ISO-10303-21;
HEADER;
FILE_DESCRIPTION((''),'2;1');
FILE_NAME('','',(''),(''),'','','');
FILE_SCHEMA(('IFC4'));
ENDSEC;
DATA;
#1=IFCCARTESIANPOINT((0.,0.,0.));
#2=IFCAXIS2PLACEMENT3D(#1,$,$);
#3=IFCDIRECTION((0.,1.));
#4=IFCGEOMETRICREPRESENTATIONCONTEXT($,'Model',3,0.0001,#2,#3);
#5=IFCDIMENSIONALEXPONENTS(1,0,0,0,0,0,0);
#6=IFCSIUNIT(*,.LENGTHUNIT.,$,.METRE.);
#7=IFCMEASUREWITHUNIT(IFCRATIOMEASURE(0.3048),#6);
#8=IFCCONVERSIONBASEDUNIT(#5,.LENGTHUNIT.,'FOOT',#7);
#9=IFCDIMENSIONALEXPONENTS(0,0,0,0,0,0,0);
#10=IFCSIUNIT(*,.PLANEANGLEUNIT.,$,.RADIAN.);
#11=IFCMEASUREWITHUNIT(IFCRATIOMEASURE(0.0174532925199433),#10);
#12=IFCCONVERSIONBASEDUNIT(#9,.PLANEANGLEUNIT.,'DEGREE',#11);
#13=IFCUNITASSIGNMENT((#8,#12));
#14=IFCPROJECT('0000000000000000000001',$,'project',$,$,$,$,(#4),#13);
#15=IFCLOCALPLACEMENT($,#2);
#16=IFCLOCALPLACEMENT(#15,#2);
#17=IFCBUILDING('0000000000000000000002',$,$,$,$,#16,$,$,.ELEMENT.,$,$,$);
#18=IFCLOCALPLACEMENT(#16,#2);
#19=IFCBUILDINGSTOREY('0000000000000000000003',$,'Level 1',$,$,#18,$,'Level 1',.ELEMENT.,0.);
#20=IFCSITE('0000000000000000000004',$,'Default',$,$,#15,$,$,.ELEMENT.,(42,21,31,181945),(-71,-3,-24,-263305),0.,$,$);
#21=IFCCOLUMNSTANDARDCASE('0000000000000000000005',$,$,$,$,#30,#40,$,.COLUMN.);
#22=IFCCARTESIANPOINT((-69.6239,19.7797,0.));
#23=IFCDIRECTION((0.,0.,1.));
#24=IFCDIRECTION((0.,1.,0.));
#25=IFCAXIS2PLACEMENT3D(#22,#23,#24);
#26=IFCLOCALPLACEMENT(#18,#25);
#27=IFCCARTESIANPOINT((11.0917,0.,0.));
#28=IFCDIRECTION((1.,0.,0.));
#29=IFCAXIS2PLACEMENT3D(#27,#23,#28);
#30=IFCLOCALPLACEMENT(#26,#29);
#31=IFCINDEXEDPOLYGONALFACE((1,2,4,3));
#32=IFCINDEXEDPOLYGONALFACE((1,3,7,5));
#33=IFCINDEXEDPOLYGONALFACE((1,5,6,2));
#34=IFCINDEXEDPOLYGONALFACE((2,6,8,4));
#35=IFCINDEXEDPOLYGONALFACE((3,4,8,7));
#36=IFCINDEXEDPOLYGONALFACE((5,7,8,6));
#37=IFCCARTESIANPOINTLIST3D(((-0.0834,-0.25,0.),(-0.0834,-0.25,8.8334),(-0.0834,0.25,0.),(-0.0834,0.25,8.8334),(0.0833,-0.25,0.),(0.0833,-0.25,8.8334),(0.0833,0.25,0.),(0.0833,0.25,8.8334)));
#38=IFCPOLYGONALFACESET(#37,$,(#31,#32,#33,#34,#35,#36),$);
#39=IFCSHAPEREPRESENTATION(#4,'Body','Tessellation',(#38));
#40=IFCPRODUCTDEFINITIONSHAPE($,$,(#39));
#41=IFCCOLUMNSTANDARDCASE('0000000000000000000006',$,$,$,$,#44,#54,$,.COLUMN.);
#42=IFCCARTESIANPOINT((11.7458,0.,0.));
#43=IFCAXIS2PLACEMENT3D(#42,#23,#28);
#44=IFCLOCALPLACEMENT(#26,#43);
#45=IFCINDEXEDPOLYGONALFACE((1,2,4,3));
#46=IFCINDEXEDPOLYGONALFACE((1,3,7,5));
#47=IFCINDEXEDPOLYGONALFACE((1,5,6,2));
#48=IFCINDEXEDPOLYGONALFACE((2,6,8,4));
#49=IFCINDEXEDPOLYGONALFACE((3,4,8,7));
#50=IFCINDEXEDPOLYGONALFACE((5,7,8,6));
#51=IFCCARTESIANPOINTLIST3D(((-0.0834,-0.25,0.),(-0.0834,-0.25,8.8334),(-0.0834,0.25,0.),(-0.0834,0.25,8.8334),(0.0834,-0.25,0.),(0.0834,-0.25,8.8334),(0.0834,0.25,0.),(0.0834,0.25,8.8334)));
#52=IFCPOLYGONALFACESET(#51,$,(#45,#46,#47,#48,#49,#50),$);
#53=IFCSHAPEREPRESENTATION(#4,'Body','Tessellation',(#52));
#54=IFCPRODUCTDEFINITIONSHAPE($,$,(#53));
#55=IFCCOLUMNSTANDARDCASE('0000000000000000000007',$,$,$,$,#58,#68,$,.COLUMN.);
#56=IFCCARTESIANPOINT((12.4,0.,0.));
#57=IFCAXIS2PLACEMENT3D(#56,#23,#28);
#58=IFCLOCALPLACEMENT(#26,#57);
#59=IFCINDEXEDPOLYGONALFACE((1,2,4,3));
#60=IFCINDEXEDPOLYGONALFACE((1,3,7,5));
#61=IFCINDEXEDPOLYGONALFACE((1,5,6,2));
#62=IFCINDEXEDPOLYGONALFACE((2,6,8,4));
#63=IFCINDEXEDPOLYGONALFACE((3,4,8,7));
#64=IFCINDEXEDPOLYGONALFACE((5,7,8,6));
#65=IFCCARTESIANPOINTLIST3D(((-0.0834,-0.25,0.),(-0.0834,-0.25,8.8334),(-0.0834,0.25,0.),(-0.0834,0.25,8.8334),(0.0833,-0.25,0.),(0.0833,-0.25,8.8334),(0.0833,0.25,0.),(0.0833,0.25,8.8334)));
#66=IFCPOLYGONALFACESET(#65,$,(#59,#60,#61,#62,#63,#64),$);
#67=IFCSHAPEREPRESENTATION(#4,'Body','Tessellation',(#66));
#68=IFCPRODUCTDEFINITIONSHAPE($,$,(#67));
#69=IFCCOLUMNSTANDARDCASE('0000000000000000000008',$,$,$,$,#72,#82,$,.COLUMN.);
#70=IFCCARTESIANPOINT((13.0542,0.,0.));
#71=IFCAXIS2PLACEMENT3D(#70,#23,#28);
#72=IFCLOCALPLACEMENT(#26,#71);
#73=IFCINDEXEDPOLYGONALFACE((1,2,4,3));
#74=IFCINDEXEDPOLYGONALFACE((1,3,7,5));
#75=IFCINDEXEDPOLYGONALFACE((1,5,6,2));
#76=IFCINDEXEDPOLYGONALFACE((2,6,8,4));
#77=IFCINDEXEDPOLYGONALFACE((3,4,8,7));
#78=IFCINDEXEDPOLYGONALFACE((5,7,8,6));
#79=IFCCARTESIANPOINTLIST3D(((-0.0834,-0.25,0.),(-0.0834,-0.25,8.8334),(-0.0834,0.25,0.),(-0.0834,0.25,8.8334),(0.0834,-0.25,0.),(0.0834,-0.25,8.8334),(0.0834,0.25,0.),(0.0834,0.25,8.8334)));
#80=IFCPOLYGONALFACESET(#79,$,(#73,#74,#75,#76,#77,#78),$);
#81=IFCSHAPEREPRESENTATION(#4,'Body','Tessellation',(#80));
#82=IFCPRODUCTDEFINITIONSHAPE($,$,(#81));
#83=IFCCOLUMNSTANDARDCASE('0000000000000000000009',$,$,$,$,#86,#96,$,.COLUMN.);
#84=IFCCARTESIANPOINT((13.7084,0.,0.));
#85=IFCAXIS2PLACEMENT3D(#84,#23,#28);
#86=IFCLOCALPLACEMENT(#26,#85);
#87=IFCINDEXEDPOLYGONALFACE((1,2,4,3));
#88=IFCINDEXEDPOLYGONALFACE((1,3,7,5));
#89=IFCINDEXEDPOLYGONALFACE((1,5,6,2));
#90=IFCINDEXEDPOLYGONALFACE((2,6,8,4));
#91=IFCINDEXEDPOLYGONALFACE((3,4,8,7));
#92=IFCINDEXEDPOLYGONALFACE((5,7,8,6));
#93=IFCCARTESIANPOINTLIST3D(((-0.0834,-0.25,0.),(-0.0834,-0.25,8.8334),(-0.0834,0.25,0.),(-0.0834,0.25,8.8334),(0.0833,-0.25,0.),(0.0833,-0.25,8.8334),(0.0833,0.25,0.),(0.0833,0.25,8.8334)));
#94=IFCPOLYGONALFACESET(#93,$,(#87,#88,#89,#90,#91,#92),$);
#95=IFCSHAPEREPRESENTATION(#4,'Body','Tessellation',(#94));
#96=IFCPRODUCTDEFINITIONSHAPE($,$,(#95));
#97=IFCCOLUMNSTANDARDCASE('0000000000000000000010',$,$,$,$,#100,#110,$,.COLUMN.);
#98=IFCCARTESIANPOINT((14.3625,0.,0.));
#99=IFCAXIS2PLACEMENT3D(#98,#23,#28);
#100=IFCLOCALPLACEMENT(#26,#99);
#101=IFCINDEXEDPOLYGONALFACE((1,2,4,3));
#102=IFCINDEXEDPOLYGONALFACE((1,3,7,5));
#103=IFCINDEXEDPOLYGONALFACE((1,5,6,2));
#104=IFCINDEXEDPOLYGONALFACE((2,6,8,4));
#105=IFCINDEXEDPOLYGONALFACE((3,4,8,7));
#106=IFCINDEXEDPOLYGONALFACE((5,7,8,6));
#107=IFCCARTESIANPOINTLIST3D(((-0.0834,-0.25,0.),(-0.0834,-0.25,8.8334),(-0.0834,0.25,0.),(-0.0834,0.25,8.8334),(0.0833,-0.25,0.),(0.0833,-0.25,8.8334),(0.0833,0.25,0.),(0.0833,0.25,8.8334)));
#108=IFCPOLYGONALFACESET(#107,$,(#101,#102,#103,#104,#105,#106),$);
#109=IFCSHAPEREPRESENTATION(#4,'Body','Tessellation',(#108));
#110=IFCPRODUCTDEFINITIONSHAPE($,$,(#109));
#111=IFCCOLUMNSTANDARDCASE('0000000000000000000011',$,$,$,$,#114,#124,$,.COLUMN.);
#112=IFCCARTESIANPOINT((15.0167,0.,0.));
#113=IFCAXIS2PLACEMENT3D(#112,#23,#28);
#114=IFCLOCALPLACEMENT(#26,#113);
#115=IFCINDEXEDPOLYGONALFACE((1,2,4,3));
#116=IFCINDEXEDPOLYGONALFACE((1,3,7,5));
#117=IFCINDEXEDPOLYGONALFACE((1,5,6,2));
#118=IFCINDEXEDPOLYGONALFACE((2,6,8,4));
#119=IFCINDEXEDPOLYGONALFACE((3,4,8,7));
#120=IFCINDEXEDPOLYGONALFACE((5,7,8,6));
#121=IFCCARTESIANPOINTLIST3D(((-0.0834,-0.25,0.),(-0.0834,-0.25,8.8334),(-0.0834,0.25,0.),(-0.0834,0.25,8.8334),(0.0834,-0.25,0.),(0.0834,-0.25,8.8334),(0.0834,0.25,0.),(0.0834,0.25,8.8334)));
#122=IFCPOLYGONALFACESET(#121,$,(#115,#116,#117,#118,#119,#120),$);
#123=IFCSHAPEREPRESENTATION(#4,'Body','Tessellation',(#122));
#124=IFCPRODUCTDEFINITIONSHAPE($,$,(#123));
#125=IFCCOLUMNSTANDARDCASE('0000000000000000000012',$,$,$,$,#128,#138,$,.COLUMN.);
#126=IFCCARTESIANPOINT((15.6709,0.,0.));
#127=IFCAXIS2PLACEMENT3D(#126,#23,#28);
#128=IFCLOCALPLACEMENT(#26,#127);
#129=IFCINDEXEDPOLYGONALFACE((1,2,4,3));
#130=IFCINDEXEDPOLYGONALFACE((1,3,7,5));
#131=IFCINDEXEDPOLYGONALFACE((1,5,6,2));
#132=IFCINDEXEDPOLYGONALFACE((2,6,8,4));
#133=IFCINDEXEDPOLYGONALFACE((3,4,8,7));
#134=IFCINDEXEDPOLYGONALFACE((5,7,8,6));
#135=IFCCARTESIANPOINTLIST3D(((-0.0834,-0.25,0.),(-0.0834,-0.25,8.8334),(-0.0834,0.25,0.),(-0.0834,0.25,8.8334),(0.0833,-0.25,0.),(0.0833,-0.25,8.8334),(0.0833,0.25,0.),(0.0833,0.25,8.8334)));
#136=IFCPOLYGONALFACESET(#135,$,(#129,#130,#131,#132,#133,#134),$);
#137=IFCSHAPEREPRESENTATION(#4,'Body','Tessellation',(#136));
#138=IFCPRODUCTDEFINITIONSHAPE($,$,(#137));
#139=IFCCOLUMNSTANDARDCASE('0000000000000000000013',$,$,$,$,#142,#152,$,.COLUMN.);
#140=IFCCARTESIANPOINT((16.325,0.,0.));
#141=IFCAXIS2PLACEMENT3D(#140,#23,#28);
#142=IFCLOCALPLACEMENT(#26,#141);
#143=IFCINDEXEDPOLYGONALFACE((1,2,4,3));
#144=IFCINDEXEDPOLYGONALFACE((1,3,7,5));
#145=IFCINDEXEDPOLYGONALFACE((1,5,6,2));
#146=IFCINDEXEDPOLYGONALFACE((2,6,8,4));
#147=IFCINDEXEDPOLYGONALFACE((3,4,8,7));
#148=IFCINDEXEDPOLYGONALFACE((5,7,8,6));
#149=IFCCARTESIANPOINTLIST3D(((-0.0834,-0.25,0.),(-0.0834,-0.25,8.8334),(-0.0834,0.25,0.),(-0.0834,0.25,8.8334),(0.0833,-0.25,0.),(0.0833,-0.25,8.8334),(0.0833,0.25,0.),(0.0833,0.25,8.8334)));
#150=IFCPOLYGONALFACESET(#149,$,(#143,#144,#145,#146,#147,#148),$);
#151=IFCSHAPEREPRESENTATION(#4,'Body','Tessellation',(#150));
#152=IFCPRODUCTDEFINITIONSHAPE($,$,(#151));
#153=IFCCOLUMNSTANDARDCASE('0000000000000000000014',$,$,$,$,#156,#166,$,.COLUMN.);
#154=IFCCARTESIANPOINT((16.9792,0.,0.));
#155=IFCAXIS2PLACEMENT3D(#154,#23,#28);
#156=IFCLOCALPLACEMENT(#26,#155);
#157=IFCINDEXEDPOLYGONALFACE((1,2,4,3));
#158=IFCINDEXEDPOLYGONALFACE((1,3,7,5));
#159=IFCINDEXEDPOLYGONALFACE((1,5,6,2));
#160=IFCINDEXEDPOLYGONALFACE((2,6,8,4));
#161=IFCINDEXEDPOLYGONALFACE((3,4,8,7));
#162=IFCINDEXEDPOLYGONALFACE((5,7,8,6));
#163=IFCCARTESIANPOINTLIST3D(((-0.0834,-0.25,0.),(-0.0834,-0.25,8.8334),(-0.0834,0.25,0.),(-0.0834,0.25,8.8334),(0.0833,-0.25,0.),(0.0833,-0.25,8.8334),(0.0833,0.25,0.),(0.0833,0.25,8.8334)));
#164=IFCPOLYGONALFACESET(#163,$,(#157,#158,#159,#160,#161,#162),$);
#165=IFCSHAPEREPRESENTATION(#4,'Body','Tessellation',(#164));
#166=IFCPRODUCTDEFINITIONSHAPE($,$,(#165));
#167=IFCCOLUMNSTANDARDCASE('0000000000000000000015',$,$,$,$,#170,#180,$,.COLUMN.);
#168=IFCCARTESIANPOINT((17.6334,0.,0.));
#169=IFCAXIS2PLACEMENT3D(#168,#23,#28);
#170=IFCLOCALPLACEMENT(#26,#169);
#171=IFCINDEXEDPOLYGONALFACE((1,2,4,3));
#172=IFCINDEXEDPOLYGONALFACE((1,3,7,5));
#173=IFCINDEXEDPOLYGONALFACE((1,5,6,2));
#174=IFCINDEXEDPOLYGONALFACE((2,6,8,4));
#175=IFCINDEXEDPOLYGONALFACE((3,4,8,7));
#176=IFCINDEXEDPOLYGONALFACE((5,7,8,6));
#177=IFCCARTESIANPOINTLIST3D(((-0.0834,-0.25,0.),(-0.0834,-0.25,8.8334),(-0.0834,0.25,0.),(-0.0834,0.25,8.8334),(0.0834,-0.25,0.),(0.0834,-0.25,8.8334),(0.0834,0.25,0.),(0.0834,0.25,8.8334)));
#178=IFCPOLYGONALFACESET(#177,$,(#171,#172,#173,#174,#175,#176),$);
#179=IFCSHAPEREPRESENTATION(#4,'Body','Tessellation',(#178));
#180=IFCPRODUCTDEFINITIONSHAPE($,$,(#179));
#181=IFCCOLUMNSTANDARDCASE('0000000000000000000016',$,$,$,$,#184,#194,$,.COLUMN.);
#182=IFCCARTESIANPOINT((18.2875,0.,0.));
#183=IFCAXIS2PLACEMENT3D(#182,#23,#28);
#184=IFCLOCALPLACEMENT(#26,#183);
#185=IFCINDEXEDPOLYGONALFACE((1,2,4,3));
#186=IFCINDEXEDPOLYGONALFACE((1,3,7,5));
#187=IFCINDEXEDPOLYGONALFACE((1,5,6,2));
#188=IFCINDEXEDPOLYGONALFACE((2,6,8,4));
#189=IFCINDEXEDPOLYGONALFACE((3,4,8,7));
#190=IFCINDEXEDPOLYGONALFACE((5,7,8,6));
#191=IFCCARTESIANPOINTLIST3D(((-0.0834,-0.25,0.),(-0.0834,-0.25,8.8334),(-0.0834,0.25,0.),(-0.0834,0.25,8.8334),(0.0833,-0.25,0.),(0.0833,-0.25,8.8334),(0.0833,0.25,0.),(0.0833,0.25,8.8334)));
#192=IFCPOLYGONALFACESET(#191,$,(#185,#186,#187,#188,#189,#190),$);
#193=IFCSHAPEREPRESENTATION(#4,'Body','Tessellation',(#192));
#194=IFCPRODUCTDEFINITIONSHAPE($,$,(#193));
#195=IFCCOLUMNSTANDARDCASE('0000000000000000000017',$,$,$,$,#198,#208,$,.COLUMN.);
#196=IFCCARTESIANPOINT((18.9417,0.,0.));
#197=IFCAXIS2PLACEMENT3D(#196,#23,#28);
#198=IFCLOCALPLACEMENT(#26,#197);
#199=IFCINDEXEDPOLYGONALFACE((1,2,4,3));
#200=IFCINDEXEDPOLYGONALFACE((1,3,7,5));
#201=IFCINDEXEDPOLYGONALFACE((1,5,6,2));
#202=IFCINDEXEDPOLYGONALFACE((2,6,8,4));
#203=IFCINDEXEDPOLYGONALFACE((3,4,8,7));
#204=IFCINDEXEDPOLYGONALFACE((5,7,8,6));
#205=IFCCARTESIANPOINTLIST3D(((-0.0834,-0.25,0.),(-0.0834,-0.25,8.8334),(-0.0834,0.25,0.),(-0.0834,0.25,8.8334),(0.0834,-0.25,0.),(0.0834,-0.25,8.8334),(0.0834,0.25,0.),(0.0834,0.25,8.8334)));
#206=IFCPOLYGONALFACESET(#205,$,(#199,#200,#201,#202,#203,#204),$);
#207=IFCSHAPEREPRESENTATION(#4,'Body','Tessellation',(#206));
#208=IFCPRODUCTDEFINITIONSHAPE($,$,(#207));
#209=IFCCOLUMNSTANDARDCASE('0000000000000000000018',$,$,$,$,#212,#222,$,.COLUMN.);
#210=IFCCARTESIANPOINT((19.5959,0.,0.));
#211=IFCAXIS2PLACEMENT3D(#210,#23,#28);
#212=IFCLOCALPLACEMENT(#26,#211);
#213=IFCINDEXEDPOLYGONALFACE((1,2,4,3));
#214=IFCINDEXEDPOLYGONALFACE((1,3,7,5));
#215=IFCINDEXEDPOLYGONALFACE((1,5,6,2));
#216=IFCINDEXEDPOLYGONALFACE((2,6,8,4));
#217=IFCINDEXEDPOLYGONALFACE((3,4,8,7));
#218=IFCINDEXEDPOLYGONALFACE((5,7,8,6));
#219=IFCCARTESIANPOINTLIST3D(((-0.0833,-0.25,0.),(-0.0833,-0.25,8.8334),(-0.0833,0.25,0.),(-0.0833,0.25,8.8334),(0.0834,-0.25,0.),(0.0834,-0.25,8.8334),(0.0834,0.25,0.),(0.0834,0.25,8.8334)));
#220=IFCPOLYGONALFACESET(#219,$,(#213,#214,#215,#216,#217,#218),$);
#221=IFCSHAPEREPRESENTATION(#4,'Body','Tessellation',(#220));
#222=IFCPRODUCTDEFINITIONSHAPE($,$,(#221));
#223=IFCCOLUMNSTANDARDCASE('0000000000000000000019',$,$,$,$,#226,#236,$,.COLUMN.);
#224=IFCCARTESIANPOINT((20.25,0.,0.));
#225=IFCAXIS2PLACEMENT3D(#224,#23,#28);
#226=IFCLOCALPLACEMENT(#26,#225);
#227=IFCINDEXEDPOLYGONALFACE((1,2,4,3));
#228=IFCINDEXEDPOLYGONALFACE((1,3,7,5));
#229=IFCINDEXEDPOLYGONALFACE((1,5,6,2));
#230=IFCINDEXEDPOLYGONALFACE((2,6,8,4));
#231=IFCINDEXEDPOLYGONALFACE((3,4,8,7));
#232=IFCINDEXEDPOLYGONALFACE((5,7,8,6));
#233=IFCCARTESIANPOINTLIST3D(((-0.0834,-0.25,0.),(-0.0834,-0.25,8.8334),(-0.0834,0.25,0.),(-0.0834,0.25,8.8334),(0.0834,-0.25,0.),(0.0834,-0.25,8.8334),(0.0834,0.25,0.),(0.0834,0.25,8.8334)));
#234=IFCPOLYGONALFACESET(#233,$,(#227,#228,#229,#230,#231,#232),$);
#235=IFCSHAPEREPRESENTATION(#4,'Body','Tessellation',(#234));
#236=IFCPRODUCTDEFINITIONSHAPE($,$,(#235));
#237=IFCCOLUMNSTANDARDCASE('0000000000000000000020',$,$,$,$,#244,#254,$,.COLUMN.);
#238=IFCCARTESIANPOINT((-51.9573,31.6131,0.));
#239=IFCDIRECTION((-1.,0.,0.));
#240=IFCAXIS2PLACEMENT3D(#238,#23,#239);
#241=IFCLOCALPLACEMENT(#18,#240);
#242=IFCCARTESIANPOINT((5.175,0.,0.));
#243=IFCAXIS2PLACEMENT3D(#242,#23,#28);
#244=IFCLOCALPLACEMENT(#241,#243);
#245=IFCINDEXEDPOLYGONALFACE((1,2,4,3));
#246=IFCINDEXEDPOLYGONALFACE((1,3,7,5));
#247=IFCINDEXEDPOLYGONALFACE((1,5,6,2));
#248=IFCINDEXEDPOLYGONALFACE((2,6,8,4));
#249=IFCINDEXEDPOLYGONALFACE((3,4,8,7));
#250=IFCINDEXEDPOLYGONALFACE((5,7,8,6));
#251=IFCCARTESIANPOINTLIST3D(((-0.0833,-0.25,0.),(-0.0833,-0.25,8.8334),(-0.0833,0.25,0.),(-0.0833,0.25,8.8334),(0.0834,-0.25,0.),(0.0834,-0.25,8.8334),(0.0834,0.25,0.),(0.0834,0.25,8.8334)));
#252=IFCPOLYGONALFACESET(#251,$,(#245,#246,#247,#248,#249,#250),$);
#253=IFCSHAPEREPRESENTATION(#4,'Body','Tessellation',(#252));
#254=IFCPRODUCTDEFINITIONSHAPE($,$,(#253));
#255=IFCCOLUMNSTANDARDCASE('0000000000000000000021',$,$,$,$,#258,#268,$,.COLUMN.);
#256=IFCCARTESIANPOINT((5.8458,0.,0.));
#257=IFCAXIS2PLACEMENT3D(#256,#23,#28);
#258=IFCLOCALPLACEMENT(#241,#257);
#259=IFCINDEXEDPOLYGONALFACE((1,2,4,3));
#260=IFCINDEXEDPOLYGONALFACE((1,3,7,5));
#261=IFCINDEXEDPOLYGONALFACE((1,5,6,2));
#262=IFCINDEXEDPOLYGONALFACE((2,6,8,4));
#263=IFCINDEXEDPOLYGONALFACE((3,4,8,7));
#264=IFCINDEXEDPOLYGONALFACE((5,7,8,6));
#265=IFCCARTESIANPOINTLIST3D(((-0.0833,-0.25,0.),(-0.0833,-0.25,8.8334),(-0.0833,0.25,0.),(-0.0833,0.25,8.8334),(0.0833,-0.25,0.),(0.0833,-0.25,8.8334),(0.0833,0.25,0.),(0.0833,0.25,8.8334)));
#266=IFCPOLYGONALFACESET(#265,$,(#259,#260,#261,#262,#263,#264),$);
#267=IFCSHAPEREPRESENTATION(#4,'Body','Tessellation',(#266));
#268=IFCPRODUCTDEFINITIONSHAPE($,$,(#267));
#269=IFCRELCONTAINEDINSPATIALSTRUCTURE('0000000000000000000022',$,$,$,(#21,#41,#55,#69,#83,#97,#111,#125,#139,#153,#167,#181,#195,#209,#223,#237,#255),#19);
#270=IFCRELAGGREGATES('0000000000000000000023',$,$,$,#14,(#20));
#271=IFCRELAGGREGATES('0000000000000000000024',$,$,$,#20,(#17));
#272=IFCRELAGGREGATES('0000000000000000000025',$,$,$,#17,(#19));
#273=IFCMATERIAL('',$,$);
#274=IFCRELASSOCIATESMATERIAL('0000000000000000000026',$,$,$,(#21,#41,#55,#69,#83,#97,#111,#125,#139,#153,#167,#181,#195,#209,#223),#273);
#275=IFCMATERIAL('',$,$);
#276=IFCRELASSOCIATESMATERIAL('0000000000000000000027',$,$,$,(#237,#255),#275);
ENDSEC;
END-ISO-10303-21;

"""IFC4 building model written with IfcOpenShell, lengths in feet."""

from ifc_helpers import new_model, entity, si_unit, converted_unit, direction, frame, origin, place, context, project, spatial, rectangle, extrude, material, element, save


model = new_model("IFC4")

# Units and contexts
model_context = context("Model", 3, precision=0.0001, world=origin(), true_north=direction((0.0, 1.0)))
ifc_project = project(units=[converted_unit("LENGTHUNIT", "FOOT", entity("IfcRatioMeasure", 0.3048), si_unit("LENGTHUNIT", "METRE"), dimensions=[1, 0, 0, 0, 0, 0, 0]), converted_unit("PLANEANGLEUNIT", "DEGREE", entity("IfcRatioMeasure", 0.0174532925199433), si_unit("PLANEANGLEUNIT", "RADIAN"), dimensions=[0, 0, 0, 0, 0, 0, 0])], contexts=[model_context])

# Site, building, storey
site_placement = place(None, origin())
site = spatial("IfcSite", under=ifc_project, at=site_placement, Name="Default", CompositionType="ELEMENT", RefLatitude=(42, 21, 31, 181945), RefLongitude=(-71, -3, -24, -263305), RefElevation=0.0)
building_placement = place(site_placement, origin())
building = spatial("IfcBuilding", under=site, at=building_placement, CompositionType="ELEMENT")
storey_placement = place(building_placement, origin())
storey = spatial("IfcBuildingStorey", under=building, at=storey_placement, Name="Level 1", LongName="Level 1", CompositionType="ELEMENT", Elevation=0.0)

# Columns
ifc_material_1 = material(Name="")
placement_1 = place(storey_placement, frame((-69.6239, 19.7797, 0.0), z_axis=(0.0, 0.0, 1.0), x_axis=(0.0, 1.0, 0.0)))
for number, where, z_axis, x_axis in (
    (1, (11.0917, 0.0, 0.0), (0.0, 0.0, 1.0), (1.0, 0.0, 0.0)),
    (2, (11.7458, 0.0, 0.0), (0.0, 0.0, 1.0), (1.0, 0.0, 0.0)),
    (3, (12.4, 0.0, 0.0), (0.0, 0.0, 1.0), (1.0, 0.0, 0.0)),
    (4, (13.0542, 0.0, 0.0), (0.0, 0.0, 1.0), (1.0, 0.0, 0.0)),
    (5, (13.7084, 0.0, 0.0), (0.0, 0.0, 1.0), (1.0, 0.0, 0.0)),
    (6, (14.3625, 0.0, 0.0), (0.0, 0.0, 1.0), (1.0, 0.0, 0.0)),
    (7, (15.0167, 0.0, 0.0), (0.0, 0.0, 1.0), (1.0, 0.0, 0.0)),
    (8, (15.6709, 0.0, 0.0), (0.0, 0.0, 1.0), (1.0, 0.0, 0.0)),
    (9, (16.325, 0.0, 0.0), (0.0, 0.0, 1.0), (1.0, 0.0, 0.0)),
    (10, (16.9792, 0.0, 0.0), (0.0, 0.0, 1.0), (1.0, 0.0, 0.0)),
    (11, (17.6334, 0.0, 0.0), (0.0, 0.0, 1.0), (1.0, 0.0, 0.0)),
    (12, (18.2875, 0.0, 0.0), (0.0, 0.0, 1.0), (1.0, 0.0, 0.0)),
    (13, (18.9417, 0.0, 0.0), (0.0, 0.0, 1.0), (1.0, 0.0, 0.0)),
    (14, (19.5959, 0.0, 0.0), (0.0, 0.0, 1.0), (1.0, 0.0, 0.0)),
    (15, (20.25, 0.0, 0.0), (0.0, 0.0, 1.0), (1.0, 0.0, 0.0)),
):
    element("IfcColumnStandardCase", number, at=place(placement_1, frame(where, z_axis=z_axis, x_axis=x_axis)), inside=storey, material=ifc_material_1, PredefinedType="COLUMN", context=model_context, shape_type="SweptSolid", body=[
        extrude(rectangle(XDim=0.1667, YDim=0.5), origin(), (0.0, 0.0, 1.0), 8.8334),
    ])
ifc_material_2 = material(Name="")
placement_2 = place(storey_placement, frame((-51.9573, 31.6131, 0.0), z_axis=(0.0, 0.0, 1.0), x_axis=(-1.0, 0.0, 0.0)))
for number, where, z_axis, x_axis in (
    (16, (5.175, 0.0, 0.0), (0.0, 0.0, 1.0), (1.0, 0.0, 0.0)),
    (17, (5.8458, 0.0, 0.0), (0.0, 0.0, 1.0), (1.0, 0.0, 0.0)),
):
    element("IfcColumnStandardCase", number, at=place(placement_2, frame(where, z_axis=z_axis, x_axis=x_axis)), inside=storey, material=ifc_material_2, PredefinedType="COLUMN", context=model_context, shape_type="SweptSolid", body=[
        extrude(rectangle(XDim=0.1667, YDim=0.5), origin(), (0.0, 0.0, 1.0), 8.8334),
    ])

save(model, "model.ifc")
